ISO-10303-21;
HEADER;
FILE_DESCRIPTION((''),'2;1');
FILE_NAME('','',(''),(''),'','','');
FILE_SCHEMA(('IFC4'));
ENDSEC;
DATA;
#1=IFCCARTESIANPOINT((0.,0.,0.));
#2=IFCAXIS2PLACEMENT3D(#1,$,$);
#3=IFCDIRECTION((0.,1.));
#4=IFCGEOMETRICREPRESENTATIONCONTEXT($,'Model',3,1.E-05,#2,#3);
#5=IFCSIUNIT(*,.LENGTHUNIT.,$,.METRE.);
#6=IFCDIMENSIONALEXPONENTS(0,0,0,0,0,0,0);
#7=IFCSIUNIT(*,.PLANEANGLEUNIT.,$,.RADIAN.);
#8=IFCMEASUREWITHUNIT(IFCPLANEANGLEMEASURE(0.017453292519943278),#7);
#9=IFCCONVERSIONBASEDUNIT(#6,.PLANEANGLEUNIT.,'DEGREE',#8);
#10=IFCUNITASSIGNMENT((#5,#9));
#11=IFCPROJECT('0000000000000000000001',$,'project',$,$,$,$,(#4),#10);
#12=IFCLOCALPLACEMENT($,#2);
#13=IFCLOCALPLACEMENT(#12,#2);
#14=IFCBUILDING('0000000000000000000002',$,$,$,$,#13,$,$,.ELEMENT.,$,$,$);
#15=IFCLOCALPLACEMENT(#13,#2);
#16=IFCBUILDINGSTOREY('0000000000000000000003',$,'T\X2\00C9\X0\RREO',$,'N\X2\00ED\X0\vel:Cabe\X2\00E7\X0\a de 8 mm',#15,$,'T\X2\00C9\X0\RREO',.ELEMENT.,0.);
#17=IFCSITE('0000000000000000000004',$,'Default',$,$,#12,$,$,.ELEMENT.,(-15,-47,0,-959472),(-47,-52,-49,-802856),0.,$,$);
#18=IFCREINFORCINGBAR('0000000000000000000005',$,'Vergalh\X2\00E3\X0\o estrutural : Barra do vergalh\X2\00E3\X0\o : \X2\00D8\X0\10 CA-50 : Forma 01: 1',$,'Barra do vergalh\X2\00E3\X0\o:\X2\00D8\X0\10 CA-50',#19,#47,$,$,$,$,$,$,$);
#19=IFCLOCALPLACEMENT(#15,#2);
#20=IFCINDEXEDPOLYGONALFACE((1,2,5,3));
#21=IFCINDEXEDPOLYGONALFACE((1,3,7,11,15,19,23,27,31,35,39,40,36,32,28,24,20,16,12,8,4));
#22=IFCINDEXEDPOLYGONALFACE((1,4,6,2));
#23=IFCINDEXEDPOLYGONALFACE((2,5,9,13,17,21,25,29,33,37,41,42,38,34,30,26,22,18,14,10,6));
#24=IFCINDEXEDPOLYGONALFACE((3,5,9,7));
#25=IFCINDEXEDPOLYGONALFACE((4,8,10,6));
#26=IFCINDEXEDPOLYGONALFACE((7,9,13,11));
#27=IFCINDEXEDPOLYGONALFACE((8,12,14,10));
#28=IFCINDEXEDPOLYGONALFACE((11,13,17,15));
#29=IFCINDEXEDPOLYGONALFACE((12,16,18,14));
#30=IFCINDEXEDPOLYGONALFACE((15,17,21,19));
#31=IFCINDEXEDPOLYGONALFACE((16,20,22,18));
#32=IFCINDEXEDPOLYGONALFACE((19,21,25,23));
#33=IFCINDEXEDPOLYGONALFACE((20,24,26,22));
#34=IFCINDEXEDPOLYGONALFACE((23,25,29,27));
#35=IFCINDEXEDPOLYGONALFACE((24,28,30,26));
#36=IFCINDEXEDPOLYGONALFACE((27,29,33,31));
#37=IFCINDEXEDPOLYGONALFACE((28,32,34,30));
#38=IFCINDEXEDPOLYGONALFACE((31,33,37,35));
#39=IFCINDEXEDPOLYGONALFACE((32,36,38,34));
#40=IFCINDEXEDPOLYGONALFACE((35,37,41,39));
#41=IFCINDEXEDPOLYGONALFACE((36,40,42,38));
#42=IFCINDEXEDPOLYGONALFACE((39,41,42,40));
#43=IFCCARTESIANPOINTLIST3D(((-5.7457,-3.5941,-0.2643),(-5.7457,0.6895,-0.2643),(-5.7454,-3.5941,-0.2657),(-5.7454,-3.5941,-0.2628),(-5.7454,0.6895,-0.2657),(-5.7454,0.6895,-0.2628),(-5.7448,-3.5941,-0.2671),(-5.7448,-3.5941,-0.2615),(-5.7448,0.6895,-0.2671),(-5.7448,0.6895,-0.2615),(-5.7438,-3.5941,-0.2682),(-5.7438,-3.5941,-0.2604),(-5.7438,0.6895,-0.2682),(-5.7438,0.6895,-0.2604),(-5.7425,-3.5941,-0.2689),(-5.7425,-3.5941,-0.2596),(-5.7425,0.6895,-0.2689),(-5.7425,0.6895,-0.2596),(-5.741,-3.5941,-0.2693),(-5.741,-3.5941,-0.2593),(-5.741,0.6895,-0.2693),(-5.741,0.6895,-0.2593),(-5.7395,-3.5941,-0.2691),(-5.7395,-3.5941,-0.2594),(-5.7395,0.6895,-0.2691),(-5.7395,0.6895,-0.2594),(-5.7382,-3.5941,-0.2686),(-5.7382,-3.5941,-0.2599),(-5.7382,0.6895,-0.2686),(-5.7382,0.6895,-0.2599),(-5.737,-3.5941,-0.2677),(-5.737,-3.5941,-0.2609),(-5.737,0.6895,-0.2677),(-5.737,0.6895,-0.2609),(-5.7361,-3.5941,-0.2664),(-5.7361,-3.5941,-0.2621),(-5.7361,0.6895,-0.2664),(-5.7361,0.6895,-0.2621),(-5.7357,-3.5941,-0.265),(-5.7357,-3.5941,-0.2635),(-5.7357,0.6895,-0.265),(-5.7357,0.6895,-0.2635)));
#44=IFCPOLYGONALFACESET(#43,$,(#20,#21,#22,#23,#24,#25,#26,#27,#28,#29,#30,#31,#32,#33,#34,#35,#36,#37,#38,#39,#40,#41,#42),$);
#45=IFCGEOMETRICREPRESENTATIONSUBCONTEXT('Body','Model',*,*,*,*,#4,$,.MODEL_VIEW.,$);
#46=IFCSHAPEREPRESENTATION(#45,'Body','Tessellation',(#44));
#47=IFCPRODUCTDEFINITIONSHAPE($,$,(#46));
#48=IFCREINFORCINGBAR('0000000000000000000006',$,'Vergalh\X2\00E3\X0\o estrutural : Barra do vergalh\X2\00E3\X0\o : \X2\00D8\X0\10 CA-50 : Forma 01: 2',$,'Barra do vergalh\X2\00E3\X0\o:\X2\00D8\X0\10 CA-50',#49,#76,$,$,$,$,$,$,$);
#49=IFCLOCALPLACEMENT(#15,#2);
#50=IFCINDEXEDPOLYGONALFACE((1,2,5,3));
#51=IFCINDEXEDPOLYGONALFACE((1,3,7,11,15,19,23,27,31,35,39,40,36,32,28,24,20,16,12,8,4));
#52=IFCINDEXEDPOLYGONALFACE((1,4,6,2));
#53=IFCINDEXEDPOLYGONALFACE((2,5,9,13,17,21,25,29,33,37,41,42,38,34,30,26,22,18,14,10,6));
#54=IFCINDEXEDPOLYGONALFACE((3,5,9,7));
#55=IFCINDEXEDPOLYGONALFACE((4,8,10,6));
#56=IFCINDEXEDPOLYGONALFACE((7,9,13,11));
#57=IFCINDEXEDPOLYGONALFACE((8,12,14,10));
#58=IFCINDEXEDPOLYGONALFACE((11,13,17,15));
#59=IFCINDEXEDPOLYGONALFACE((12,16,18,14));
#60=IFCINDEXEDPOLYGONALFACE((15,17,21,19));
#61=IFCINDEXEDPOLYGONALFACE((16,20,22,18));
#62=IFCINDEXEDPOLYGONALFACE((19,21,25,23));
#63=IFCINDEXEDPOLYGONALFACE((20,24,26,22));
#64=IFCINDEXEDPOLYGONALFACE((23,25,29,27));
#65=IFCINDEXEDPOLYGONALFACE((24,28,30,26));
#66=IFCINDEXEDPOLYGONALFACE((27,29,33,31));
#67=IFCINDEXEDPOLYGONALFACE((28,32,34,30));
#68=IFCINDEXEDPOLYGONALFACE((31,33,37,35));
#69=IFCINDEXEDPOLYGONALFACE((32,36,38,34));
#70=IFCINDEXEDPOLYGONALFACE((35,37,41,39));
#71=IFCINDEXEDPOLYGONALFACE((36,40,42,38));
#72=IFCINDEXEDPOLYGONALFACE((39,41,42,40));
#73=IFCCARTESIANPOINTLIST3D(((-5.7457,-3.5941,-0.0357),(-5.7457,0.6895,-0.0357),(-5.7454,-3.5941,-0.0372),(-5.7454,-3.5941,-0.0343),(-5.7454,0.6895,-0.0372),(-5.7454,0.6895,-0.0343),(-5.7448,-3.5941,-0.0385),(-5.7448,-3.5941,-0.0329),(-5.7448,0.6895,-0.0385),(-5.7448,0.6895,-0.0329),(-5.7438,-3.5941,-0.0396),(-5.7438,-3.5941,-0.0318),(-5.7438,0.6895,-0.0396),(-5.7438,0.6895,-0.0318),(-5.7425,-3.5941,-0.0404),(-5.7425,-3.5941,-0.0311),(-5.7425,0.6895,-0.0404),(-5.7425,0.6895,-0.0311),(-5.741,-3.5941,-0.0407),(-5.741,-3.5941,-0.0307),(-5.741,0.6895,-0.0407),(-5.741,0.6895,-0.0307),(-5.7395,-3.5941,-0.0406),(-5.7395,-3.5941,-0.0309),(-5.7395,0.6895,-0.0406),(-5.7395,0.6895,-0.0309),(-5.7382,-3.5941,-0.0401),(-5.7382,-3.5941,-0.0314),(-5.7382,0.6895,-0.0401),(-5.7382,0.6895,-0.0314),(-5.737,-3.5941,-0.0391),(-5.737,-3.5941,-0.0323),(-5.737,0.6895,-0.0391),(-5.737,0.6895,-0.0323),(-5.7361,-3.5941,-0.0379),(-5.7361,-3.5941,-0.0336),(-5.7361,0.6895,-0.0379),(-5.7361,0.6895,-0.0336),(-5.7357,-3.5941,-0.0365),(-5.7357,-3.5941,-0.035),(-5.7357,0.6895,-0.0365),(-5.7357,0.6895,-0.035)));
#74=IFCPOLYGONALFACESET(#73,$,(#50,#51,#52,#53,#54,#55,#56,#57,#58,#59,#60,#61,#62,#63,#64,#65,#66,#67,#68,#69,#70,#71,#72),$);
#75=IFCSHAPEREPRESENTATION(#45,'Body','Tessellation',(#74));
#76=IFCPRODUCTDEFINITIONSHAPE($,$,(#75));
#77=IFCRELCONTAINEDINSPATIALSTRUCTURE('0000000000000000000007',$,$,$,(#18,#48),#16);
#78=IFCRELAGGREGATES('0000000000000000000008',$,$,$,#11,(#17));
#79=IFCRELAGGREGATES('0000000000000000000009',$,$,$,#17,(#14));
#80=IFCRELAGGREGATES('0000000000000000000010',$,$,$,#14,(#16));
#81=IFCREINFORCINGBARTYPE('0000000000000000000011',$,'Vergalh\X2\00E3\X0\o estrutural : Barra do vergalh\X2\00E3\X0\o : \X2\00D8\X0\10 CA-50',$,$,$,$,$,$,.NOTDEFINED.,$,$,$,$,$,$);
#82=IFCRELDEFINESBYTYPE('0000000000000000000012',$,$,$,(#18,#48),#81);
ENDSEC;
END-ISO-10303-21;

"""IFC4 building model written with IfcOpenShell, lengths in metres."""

from ifc_helpers import new_model, entity, si_unit, converted_unit, direction, origin, place, context, subcontext, project, spatial, type_object, element, save


model = new_model("IFC4")

# Units and contexts
model_context = context("Model", 3, precision=1e-05, world=origin(), true_north=direction((0.0, 1.0)))
body_context = subcontext(model_context, "Body", "Model", "MODEL_VIEW")
ifc_project = project(units=[si_unit("LENGTHUNIT", "METRE"), converted_unit("PLANEANGLEUNIT", "DEGREE", entity("IfcPlaneAngleMeasure", 0.017453292519943278), si_unit("PLANEANGLEUNIT", "RADIAN"), dimensions=[0, 0, 0, 0, 0, 0, 0])], contexts=[model_context])

# Site, building, storey
site_placement = place(None, origin())
site = spatial("IfcSite", under=ifc_project, at=site_placement, Name="Default", CompositionType="ELEMENT", RefLatitude=(-15, -47, 0, -959472), RefLongitude=(-47, -52, -49, -802856), RefElevation=0.0)
building_placement = place(site_placement, origin())
building = spatial("IfcBuilding", under=site, at=building_placement, CompositionType="ELEMENT")
storey_placement = place(building_placement, origin())
storey = spatial("IfcBuildingStorey", under=building, at=storey_placement, Name="TÉRREO", ObjectType="Nível:Cabeça de 8 mm", LongName="TÉRREO", CompositionType="ELEMENT", Elevation=0.0)

# Reinforcing bars
reinforcing_bar_type_1 = type_object("IfcReinforcingBarType", Name="Vergalhão estrutural : Barra do vergalhão : Ø10 CA-50", PredefinedType="NOTDEFINED")
reinforcing_bar_1_placement = place(storey_placement, origin())
element("IfcReinforcingBar", 1, at=reinforcing_bar_1_placement, inside=storey, type_object=reinforcing_bar_type_1, Name="Vergalhão estrutural : Barra do vergalhão : Ø10 CA-50 : Forma 01: 1", ObjectType="Barra do vergalhão:Ø10 CA-50", context=body_context, shape_type="AdvancedSweptSolid", body=[
    entity("IfcSweptDiskSolid", entity("IfcIndexedPolyCurve", entity("IfcCartesianPointList3D", [[-5.7407, 0.6895, -0.2643], [-5.7407, -3.5941, -0.2643]]), None, False), 0.005, None, 0.0, 1.0),
])
reinforcing_bar_2_placement = place(storey_placement, origin())
element("IfcReinforcingBar", 2, at=reinforcing_bar_2_placement, inside=storey, type_object=reinforcing_bar_type_1, Name="Vergalhão estrutural : Barra do vergalhão : Ø10 CA-50 : Forma 01: 2", ObjectType="Barra do vergalhão:Ø10 CA-50", context=body_context, shape_type="AdvancedSweptSolid", body=[
    entity("IfcSweptDiskSolid", entity("IfcIndexedPolyCurve", entity("IfcCartesianPointList3D", [[-5.7407, 0.6895, -0.0357], [-5.7407, -3.5941, -0.0357]]), None, False), 0.005, None, 0.0, 1.0),
])

save(model, "model.ifc")
